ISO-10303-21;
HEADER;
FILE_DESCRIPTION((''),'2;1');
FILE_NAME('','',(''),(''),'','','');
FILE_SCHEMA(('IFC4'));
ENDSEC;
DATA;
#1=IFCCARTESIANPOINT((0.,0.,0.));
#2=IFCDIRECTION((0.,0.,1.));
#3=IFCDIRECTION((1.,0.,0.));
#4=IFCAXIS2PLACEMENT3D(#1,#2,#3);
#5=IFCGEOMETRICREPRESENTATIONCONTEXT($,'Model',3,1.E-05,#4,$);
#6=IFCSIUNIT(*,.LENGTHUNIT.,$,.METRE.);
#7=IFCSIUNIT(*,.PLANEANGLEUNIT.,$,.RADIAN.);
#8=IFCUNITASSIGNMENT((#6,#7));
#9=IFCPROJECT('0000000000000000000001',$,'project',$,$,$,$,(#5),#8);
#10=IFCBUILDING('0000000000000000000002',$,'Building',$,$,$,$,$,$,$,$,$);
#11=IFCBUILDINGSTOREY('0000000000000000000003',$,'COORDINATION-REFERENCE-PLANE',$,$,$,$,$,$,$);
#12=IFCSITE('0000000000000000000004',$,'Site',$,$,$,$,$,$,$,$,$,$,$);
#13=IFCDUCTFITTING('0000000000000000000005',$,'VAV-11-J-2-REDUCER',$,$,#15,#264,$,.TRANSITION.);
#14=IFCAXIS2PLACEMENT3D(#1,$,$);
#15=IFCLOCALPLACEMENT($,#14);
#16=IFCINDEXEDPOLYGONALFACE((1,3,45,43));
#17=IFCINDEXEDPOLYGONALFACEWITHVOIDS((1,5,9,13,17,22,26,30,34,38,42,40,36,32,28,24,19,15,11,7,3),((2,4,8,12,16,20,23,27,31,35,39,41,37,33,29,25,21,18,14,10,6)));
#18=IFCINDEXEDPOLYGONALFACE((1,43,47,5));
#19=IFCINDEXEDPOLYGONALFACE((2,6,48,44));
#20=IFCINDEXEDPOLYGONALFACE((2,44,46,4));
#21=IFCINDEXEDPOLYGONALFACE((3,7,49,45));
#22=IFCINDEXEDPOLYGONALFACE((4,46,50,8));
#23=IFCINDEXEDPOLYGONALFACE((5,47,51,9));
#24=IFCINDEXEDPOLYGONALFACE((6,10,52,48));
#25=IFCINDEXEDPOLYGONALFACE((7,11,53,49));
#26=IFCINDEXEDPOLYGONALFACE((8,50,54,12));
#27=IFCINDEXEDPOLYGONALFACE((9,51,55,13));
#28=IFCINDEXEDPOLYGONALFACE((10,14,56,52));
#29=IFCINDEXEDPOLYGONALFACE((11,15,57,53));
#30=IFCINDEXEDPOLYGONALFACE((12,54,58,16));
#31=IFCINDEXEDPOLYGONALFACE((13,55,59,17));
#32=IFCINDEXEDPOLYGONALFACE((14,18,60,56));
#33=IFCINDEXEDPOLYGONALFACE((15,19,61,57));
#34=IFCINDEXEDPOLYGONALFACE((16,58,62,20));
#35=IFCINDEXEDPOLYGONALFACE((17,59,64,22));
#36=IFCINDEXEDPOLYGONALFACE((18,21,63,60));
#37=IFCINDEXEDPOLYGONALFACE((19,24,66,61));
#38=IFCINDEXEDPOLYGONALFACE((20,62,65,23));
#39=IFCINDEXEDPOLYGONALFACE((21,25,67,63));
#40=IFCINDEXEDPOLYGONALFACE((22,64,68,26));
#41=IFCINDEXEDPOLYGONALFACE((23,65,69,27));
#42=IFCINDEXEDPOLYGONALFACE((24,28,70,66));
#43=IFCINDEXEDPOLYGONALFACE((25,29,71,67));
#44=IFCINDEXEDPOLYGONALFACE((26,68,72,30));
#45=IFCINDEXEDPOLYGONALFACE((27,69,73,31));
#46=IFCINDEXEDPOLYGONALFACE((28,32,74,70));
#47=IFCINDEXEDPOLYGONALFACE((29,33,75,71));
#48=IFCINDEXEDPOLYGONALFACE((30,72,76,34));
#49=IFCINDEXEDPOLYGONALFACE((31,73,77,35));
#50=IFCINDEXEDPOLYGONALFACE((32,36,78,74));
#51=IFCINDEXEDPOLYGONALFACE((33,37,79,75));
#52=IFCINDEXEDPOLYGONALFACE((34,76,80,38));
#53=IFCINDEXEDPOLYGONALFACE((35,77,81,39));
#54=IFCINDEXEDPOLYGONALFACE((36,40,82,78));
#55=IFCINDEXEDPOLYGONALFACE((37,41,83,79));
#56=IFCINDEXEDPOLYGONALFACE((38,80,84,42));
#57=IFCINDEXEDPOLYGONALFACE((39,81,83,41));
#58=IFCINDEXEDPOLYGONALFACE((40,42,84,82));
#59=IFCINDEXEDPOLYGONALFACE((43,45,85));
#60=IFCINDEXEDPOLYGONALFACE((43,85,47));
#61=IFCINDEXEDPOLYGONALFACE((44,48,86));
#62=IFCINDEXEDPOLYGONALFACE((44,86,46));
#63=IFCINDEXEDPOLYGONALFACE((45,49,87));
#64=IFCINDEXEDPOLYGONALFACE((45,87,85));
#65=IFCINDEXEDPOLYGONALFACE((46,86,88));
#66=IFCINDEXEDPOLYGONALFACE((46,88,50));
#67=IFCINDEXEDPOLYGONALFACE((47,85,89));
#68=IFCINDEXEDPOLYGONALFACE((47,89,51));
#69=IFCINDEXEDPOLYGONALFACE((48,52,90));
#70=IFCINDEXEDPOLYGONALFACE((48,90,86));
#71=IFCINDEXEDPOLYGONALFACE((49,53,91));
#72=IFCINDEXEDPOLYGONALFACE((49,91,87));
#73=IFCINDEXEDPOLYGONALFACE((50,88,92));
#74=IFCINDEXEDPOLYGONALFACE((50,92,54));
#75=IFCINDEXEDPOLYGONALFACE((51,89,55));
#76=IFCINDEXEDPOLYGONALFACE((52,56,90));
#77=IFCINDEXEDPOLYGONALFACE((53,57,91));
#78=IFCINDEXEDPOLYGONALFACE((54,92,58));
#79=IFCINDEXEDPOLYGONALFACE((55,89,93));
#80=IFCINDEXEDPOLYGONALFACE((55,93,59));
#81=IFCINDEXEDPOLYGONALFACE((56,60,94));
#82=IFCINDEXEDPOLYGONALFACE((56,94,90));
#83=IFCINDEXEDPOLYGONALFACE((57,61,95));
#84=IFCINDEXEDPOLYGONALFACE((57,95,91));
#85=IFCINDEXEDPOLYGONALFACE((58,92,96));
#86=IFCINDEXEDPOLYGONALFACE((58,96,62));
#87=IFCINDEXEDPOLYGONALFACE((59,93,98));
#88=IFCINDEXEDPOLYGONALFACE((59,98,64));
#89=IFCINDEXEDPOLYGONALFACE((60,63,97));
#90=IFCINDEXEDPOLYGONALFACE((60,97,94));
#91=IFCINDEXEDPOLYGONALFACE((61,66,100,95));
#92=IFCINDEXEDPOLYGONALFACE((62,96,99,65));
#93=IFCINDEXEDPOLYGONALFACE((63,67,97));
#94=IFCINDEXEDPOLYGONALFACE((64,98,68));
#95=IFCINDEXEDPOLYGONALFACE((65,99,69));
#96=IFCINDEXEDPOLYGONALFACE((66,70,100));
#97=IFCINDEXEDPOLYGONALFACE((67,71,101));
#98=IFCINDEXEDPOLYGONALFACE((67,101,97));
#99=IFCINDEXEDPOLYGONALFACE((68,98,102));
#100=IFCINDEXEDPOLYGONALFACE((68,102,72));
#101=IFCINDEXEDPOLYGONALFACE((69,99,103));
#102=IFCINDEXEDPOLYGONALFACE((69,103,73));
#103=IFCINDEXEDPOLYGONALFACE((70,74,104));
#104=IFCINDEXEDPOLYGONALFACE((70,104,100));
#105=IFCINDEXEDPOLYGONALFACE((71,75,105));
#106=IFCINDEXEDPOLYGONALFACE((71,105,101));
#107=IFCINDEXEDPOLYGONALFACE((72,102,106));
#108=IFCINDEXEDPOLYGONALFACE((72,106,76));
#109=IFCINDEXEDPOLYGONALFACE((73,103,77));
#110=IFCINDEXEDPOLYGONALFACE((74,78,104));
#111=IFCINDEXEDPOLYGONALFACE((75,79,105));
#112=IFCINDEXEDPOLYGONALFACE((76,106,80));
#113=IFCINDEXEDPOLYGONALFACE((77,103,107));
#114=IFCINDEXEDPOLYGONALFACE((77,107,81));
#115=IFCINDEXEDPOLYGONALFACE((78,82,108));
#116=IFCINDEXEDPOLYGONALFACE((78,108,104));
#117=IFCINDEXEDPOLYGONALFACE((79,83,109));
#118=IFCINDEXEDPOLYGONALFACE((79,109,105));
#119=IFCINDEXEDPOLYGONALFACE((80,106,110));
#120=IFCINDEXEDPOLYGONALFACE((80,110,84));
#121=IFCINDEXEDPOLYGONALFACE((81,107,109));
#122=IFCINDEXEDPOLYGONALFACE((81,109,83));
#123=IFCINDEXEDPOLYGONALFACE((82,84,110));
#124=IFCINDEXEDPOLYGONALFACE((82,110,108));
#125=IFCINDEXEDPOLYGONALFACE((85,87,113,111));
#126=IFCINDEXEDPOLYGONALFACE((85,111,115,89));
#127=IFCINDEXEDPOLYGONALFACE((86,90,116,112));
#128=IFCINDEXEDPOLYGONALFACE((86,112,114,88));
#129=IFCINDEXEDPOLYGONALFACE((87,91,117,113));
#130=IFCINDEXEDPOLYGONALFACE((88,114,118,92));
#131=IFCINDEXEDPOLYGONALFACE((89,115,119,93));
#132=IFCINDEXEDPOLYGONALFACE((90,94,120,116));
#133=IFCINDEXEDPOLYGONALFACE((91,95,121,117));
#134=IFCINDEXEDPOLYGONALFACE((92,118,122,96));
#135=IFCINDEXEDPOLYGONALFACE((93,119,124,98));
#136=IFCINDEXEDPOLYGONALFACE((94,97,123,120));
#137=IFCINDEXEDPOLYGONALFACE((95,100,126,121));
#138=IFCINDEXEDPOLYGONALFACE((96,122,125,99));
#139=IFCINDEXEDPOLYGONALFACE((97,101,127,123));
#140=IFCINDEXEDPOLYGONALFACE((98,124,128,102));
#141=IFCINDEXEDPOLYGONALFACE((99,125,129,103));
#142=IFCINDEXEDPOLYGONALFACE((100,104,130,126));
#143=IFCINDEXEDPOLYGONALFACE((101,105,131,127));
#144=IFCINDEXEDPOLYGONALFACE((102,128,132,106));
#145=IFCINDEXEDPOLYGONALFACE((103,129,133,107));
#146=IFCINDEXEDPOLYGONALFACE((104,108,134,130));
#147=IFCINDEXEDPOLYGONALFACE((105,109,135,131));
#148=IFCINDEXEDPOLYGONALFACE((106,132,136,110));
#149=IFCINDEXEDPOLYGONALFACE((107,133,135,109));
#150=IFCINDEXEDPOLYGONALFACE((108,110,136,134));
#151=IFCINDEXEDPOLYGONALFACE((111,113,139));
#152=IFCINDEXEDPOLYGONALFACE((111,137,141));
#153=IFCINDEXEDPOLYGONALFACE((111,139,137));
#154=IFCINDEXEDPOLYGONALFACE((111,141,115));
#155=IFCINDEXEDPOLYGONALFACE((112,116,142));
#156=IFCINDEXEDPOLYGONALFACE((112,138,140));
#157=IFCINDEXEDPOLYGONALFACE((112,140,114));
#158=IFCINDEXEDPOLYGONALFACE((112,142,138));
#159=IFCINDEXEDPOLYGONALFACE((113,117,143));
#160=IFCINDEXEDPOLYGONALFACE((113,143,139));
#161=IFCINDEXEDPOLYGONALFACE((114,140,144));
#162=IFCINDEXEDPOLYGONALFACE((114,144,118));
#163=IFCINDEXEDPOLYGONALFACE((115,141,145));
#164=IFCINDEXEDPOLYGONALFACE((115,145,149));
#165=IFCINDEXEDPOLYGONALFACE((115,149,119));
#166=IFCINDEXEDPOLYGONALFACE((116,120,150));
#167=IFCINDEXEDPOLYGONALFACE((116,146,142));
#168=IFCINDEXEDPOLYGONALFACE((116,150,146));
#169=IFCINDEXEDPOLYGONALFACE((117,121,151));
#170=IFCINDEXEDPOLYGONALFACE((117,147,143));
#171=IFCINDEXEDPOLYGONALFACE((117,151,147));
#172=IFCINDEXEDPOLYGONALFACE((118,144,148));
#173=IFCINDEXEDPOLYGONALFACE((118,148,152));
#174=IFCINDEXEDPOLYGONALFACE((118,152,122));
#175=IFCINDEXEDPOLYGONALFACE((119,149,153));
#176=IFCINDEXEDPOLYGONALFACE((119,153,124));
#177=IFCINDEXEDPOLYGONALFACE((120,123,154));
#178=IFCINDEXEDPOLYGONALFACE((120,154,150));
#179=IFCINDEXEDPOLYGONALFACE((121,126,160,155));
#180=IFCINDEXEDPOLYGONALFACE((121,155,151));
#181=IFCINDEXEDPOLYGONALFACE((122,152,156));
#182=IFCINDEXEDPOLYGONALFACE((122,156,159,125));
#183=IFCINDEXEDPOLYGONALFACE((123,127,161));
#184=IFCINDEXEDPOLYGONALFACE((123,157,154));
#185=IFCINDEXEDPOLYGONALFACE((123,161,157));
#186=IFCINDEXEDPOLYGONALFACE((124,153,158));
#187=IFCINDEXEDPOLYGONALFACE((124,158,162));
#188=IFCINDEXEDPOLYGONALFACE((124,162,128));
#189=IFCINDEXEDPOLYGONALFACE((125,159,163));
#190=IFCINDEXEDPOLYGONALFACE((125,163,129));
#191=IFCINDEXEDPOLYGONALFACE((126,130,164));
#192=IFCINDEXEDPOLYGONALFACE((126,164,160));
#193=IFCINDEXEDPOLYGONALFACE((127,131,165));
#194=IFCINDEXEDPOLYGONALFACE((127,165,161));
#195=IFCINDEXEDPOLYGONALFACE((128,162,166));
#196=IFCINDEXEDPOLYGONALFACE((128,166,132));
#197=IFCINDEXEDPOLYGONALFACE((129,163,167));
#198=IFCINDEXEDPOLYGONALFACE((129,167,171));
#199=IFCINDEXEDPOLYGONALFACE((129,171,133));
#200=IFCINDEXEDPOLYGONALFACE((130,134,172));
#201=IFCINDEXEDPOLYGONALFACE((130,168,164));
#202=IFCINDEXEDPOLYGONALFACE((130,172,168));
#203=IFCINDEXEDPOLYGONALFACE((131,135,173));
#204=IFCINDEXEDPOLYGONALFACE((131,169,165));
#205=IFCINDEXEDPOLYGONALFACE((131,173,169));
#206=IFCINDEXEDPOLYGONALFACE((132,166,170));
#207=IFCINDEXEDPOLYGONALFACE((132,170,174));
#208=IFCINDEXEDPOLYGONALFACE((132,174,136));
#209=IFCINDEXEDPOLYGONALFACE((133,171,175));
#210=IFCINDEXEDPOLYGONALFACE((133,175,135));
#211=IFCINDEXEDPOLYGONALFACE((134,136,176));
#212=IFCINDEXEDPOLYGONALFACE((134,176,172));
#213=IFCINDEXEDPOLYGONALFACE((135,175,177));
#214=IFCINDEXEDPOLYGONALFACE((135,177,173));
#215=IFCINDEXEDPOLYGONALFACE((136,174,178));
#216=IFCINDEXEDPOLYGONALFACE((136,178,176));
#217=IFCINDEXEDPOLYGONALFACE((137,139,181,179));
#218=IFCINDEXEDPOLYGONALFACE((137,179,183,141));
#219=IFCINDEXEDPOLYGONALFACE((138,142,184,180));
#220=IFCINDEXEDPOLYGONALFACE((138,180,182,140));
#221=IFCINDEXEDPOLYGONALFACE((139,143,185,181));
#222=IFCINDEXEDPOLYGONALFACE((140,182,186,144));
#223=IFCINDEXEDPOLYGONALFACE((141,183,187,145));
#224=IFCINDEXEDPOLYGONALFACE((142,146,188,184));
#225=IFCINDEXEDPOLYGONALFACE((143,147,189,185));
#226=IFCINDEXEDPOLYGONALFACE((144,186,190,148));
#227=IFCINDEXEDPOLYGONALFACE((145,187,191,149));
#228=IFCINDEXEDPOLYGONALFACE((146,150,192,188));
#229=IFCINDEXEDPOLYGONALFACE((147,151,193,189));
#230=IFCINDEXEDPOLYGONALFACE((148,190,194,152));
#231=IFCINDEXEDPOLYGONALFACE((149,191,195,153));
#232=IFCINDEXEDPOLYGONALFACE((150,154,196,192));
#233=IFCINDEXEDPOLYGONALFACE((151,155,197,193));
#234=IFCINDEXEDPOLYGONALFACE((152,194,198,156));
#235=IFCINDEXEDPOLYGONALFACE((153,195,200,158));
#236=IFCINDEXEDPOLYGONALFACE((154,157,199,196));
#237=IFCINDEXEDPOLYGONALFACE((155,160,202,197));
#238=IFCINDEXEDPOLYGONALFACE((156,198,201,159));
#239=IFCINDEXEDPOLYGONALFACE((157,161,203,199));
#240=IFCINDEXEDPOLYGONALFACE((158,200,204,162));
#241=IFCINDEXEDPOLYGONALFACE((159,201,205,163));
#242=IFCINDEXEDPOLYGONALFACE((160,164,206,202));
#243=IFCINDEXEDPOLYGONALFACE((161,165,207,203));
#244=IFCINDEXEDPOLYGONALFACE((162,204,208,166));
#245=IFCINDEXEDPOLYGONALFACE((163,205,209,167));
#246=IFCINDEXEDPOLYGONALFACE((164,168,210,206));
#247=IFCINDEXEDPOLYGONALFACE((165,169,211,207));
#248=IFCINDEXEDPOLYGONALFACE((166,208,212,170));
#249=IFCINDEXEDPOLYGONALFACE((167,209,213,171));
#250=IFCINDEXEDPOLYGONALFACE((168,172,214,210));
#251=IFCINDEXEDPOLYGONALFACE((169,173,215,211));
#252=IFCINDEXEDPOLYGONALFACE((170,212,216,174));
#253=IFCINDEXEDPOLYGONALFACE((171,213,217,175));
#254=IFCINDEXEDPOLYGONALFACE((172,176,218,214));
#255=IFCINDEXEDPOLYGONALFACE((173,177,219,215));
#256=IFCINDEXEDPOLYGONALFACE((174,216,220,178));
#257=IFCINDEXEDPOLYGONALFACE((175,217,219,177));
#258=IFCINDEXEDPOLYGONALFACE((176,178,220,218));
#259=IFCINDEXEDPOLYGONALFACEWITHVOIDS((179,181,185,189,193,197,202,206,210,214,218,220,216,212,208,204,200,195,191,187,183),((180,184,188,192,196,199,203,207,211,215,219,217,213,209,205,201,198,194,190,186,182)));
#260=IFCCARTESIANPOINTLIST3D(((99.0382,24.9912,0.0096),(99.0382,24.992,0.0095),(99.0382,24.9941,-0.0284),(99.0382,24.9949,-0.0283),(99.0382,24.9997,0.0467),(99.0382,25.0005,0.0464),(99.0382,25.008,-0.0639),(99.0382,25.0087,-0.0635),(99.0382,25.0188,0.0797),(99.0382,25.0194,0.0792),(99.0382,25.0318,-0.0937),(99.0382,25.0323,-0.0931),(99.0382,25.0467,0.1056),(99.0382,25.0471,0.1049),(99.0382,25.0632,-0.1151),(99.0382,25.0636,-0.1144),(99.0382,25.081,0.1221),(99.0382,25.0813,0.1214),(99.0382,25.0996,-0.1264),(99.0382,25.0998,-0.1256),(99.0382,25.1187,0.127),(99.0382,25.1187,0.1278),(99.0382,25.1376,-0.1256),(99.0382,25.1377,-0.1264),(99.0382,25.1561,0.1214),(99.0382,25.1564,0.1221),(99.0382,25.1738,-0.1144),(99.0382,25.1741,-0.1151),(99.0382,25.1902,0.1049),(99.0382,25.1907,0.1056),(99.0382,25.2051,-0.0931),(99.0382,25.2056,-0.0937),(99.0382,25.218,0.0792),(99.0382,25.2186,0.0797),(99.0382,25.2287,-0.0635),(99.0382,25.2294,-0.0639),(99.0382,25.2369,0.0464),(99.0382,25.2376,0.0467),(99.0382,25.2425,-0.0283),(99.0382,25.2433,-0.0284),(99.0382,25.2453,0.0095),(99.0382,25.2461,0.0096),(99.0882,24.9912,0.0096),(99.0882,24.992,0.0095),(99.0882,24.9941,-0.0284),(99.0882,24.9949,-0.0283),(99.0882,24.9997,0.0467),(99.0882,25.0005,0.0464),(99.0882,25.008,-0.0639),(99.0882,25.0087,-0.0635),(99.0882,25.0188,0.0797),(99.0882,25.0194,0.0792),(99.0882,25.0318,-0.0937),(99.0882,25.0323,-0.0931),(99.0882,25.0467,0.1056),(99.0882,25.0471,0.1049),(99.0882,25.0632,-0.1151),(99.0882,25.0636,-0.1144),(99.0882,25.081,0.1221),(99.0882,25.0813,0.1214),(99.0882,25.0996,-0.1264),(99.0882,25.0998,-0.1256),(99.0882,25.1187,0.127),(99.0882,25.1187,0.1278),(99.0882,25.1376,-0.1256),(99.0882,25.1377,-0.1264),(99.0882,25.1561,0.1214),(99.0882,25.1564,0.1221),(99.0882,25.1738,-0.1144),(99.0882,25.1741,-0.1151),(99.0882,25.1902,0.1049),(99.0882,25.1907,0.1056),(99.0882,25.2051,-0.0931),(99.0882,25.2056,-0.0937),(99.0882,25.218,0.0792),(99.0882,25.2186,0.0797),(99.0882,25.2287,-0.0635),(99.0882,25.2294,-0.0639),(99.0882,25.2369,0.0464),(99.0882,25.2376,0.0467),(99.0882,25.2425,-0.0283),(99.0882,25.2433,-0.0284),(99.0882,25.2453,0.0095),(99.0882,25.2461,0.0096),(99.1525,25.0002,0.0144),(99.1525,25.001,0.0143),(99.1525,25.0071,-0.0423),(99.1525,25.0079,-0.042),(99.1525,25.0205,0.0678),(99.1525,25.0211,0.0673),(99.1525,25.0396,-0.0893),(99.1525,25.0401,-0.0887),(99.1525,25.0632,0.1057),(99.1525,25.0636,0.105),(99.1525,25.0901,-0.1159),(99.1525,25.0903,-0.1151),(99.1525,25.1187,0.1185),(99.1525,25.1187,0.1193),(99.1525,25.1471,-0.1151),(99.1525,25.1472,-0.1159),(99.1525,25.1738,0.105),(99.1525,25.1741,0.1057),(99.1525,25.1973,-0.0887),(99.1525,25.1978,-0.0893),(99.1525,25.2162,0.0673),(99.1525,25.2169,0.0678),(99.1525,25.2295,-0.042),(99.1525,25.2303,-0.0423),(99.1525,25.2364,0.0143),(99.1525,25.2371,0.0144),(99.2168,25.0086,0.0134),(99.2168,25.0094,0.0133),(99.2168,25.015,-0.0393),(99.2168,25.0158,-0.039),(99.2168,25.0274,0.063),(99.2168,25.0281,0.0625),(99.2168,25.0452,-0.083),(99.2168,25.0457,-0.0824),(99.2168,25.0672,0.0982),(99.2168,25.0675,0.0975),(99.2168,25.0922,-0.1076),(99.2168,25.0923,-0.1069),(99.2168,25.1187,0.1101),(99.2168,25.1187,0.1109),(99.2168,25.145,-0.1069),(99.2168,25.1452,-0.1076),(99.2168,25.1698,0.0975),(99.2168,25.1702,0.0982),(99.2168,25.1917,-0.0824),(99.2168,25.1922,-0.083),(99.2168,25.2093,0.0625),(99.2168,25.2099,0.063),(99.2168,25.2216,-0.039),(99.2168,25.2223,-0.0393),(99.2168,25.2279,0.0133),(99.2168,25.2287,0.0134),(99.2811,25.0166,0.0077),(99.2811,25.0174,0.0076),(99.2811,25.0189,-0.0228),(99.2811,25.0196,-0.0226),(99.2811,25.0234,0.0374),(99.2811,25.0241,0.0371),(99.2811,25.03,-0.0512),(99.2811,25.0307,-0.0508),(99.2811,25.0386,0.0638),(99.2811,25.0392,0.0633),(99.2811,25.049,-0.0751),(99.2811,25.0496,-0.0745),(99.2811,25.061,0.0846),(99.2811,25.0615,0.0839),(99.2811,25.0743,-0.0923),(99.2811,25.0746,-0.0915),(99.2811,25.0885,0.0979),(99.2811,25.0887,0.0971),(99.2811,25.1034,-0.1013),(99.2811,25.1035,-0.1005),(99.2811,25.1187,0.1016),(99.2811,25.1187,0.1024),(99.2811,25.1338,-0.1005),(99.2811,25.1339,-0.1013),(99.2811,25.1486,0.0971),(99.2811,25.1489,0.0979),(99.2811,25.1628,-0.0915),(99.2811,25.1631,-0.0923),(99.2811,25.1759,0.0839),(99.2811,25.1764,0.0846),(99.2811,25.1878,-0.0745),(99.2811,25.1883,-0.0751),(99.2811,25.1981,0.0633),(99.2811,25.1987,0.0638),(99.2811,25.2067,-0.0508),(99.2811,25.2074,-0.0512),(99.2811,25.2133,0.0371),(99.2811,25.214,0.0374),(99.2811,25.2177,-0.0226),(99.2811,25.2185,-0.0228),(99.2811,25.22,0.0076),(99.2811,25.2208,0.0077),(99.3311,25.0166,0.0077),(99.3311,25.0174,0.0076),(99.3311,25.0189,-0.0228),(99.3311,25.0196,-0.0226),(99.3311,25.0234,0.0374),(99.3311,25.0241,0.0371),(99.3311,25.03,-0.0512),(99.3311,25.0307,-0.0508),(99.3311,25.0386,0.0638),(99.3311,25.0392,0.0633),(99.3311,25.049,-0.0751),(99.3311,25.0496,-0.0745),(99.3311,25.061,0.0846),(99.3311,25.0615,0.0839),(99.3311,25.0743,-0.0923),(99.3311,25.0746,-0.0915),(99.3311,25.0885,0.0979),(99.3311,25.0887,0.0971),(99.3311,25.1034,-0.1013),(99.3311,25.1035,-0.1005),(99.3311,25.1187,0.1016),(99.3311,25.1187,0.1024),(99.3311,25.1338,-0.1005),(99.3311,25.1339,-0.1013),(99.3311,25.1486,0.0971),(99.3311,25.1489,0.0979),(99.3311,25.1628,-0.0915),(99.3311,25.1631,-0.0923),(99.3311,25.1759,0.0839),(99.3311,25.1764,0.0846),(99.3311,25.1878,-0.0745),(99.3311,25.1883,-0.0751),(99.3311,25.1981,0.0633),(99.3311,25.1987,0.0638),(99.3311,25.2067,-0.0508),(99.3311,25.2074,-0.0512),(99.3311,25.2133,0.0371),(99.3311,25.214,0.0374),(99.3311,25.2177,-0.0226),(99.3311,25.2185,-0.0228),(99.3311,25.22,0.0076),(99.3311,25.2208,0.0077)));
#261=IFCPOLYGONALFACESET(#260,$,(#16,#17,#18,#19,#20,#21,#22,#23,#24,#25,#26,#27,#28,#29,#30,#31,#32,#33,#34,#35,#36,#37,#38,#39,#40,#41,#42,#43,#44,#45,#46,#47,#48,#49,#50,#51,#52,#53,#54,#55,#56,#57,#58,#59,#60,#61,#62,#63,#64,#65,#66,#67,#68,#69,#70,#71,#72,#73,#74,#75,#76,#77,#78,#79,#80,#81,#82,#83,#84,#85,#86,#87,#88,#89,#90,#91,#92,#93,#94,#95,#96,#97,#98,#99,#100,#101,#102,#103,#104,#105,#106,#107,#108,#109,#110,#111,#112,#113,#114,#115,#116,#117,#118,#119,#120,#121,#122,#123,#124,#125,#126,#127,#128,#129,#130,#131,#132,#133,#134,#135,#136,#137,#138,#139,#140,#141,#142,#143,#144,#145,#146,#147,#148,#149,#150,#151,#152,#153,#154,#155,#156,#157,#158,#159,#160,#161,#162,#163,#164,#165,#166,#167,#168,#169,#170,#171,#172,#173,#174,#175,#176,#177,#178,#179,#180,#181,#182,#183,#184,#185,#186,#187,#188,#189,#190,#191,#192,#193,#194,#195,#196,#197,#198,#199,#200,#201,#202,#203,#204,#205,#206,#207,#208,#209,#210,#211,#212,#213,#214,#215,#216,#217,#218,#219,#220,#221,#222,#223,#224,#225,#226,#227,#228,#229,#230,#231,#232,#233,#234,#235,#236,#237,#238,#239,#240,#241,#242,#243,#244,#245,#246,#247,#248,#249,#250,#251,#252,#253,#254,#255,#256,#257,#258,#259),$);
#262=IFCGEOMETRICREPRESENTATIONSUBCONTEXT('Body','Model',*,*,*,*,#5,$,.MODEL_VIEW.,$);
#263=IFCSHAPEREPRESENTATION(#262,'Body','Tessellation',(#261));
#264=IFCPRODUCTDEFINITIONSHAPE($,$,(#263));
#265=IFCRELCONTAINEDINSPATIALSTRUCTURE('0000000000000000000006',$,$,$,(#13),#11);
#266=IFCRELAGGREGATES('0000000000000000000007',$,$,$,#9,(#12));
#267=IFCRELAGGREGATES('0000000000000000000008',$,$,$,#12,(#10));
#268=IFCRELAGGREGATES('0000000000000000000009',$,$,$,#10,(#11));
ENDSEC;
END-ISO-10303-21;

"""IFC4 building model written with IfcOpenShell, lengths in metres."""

from ifc_helpers import new_model, entity, si_unit, frame, origin_with_axes, place, context, subcontext, project, spatial, element, save


model = new_model("IFC4")

# Units and contexts
model_context = context("Model", 3, precision=1e-05, world=origin_with_axes())
body_context_1 = subcontext(model_context, "Body", "Model", "MODEL_VIEW")
ifc_project = project(units=[si_unit("LENGTHUNIT", "METRE"), si_unit("PLANEANGLEUNIT", "RADIAN")], contexts=[model_context])

# Site, building, storey
site = spatial("IfcSite", under=ifc_project, Name="Site")
building = spatial("IfcBuilding", under=site, Name="Building")
storey = spatial("IfcBuildingStorey", under=building, Name="COORDINATION-REFERENCE-PLANE")

# Duct fitting
for number, where, z_axis, x_axis, name in (
    (1, (99.0382, 25.1187, 0.0), (0.0, 1.0, 0.0), (0.0, 0.0, 1.0), "VAV-11-J-2-REDUCER"),
):
    element("IfcDuctFitting", number, at=place(None, frame(where, z_axis=z_axis, x_axis=x_axis)), inside=storey, Name=name, PredefinedType="TRANSITION", context=body_context_1, shape_type="SweptSolid", body=[
        entity("IfcRevolvedAreaSolid", entity("IfcArbitraryClosedProfileDef", "AREA", None, entity("IfcPolyline", [entity("IfcCartesianPoint", [0.1278, 0.0]), entity("IfcCartesianPoint", [0.1278, 0.05]), entity("IfcCartesianPoint", [0.1024, 0.2429]), entity("IfcCartesianPoint", [0.1024, 0.2929]), entity("IfcCartesianPoint", [0.1016, 0.2929]), entity("IfcCartesianPoint", [0.1016, 0.2429]), entity("IfcCartesianPoint", [0.127, 0.05]), entity("IfcCartesianPoint", [0.127, 0.0]), entity("IfcCartesianPoint", [0.1278, 0.0])])), entity("IfcAxis2Placement3D", entity("IfcCartesianPoint", [0.0, 0.0, 0.0])), entity("IfcAxis1Placement", entity("IfcCartesianPoint", [0.0, 0.0, 0.0]), entity("IfcDirection", [0.0, 1.0, 0.0])), 6.283185),
    ])

save(model, "model.ifc")
